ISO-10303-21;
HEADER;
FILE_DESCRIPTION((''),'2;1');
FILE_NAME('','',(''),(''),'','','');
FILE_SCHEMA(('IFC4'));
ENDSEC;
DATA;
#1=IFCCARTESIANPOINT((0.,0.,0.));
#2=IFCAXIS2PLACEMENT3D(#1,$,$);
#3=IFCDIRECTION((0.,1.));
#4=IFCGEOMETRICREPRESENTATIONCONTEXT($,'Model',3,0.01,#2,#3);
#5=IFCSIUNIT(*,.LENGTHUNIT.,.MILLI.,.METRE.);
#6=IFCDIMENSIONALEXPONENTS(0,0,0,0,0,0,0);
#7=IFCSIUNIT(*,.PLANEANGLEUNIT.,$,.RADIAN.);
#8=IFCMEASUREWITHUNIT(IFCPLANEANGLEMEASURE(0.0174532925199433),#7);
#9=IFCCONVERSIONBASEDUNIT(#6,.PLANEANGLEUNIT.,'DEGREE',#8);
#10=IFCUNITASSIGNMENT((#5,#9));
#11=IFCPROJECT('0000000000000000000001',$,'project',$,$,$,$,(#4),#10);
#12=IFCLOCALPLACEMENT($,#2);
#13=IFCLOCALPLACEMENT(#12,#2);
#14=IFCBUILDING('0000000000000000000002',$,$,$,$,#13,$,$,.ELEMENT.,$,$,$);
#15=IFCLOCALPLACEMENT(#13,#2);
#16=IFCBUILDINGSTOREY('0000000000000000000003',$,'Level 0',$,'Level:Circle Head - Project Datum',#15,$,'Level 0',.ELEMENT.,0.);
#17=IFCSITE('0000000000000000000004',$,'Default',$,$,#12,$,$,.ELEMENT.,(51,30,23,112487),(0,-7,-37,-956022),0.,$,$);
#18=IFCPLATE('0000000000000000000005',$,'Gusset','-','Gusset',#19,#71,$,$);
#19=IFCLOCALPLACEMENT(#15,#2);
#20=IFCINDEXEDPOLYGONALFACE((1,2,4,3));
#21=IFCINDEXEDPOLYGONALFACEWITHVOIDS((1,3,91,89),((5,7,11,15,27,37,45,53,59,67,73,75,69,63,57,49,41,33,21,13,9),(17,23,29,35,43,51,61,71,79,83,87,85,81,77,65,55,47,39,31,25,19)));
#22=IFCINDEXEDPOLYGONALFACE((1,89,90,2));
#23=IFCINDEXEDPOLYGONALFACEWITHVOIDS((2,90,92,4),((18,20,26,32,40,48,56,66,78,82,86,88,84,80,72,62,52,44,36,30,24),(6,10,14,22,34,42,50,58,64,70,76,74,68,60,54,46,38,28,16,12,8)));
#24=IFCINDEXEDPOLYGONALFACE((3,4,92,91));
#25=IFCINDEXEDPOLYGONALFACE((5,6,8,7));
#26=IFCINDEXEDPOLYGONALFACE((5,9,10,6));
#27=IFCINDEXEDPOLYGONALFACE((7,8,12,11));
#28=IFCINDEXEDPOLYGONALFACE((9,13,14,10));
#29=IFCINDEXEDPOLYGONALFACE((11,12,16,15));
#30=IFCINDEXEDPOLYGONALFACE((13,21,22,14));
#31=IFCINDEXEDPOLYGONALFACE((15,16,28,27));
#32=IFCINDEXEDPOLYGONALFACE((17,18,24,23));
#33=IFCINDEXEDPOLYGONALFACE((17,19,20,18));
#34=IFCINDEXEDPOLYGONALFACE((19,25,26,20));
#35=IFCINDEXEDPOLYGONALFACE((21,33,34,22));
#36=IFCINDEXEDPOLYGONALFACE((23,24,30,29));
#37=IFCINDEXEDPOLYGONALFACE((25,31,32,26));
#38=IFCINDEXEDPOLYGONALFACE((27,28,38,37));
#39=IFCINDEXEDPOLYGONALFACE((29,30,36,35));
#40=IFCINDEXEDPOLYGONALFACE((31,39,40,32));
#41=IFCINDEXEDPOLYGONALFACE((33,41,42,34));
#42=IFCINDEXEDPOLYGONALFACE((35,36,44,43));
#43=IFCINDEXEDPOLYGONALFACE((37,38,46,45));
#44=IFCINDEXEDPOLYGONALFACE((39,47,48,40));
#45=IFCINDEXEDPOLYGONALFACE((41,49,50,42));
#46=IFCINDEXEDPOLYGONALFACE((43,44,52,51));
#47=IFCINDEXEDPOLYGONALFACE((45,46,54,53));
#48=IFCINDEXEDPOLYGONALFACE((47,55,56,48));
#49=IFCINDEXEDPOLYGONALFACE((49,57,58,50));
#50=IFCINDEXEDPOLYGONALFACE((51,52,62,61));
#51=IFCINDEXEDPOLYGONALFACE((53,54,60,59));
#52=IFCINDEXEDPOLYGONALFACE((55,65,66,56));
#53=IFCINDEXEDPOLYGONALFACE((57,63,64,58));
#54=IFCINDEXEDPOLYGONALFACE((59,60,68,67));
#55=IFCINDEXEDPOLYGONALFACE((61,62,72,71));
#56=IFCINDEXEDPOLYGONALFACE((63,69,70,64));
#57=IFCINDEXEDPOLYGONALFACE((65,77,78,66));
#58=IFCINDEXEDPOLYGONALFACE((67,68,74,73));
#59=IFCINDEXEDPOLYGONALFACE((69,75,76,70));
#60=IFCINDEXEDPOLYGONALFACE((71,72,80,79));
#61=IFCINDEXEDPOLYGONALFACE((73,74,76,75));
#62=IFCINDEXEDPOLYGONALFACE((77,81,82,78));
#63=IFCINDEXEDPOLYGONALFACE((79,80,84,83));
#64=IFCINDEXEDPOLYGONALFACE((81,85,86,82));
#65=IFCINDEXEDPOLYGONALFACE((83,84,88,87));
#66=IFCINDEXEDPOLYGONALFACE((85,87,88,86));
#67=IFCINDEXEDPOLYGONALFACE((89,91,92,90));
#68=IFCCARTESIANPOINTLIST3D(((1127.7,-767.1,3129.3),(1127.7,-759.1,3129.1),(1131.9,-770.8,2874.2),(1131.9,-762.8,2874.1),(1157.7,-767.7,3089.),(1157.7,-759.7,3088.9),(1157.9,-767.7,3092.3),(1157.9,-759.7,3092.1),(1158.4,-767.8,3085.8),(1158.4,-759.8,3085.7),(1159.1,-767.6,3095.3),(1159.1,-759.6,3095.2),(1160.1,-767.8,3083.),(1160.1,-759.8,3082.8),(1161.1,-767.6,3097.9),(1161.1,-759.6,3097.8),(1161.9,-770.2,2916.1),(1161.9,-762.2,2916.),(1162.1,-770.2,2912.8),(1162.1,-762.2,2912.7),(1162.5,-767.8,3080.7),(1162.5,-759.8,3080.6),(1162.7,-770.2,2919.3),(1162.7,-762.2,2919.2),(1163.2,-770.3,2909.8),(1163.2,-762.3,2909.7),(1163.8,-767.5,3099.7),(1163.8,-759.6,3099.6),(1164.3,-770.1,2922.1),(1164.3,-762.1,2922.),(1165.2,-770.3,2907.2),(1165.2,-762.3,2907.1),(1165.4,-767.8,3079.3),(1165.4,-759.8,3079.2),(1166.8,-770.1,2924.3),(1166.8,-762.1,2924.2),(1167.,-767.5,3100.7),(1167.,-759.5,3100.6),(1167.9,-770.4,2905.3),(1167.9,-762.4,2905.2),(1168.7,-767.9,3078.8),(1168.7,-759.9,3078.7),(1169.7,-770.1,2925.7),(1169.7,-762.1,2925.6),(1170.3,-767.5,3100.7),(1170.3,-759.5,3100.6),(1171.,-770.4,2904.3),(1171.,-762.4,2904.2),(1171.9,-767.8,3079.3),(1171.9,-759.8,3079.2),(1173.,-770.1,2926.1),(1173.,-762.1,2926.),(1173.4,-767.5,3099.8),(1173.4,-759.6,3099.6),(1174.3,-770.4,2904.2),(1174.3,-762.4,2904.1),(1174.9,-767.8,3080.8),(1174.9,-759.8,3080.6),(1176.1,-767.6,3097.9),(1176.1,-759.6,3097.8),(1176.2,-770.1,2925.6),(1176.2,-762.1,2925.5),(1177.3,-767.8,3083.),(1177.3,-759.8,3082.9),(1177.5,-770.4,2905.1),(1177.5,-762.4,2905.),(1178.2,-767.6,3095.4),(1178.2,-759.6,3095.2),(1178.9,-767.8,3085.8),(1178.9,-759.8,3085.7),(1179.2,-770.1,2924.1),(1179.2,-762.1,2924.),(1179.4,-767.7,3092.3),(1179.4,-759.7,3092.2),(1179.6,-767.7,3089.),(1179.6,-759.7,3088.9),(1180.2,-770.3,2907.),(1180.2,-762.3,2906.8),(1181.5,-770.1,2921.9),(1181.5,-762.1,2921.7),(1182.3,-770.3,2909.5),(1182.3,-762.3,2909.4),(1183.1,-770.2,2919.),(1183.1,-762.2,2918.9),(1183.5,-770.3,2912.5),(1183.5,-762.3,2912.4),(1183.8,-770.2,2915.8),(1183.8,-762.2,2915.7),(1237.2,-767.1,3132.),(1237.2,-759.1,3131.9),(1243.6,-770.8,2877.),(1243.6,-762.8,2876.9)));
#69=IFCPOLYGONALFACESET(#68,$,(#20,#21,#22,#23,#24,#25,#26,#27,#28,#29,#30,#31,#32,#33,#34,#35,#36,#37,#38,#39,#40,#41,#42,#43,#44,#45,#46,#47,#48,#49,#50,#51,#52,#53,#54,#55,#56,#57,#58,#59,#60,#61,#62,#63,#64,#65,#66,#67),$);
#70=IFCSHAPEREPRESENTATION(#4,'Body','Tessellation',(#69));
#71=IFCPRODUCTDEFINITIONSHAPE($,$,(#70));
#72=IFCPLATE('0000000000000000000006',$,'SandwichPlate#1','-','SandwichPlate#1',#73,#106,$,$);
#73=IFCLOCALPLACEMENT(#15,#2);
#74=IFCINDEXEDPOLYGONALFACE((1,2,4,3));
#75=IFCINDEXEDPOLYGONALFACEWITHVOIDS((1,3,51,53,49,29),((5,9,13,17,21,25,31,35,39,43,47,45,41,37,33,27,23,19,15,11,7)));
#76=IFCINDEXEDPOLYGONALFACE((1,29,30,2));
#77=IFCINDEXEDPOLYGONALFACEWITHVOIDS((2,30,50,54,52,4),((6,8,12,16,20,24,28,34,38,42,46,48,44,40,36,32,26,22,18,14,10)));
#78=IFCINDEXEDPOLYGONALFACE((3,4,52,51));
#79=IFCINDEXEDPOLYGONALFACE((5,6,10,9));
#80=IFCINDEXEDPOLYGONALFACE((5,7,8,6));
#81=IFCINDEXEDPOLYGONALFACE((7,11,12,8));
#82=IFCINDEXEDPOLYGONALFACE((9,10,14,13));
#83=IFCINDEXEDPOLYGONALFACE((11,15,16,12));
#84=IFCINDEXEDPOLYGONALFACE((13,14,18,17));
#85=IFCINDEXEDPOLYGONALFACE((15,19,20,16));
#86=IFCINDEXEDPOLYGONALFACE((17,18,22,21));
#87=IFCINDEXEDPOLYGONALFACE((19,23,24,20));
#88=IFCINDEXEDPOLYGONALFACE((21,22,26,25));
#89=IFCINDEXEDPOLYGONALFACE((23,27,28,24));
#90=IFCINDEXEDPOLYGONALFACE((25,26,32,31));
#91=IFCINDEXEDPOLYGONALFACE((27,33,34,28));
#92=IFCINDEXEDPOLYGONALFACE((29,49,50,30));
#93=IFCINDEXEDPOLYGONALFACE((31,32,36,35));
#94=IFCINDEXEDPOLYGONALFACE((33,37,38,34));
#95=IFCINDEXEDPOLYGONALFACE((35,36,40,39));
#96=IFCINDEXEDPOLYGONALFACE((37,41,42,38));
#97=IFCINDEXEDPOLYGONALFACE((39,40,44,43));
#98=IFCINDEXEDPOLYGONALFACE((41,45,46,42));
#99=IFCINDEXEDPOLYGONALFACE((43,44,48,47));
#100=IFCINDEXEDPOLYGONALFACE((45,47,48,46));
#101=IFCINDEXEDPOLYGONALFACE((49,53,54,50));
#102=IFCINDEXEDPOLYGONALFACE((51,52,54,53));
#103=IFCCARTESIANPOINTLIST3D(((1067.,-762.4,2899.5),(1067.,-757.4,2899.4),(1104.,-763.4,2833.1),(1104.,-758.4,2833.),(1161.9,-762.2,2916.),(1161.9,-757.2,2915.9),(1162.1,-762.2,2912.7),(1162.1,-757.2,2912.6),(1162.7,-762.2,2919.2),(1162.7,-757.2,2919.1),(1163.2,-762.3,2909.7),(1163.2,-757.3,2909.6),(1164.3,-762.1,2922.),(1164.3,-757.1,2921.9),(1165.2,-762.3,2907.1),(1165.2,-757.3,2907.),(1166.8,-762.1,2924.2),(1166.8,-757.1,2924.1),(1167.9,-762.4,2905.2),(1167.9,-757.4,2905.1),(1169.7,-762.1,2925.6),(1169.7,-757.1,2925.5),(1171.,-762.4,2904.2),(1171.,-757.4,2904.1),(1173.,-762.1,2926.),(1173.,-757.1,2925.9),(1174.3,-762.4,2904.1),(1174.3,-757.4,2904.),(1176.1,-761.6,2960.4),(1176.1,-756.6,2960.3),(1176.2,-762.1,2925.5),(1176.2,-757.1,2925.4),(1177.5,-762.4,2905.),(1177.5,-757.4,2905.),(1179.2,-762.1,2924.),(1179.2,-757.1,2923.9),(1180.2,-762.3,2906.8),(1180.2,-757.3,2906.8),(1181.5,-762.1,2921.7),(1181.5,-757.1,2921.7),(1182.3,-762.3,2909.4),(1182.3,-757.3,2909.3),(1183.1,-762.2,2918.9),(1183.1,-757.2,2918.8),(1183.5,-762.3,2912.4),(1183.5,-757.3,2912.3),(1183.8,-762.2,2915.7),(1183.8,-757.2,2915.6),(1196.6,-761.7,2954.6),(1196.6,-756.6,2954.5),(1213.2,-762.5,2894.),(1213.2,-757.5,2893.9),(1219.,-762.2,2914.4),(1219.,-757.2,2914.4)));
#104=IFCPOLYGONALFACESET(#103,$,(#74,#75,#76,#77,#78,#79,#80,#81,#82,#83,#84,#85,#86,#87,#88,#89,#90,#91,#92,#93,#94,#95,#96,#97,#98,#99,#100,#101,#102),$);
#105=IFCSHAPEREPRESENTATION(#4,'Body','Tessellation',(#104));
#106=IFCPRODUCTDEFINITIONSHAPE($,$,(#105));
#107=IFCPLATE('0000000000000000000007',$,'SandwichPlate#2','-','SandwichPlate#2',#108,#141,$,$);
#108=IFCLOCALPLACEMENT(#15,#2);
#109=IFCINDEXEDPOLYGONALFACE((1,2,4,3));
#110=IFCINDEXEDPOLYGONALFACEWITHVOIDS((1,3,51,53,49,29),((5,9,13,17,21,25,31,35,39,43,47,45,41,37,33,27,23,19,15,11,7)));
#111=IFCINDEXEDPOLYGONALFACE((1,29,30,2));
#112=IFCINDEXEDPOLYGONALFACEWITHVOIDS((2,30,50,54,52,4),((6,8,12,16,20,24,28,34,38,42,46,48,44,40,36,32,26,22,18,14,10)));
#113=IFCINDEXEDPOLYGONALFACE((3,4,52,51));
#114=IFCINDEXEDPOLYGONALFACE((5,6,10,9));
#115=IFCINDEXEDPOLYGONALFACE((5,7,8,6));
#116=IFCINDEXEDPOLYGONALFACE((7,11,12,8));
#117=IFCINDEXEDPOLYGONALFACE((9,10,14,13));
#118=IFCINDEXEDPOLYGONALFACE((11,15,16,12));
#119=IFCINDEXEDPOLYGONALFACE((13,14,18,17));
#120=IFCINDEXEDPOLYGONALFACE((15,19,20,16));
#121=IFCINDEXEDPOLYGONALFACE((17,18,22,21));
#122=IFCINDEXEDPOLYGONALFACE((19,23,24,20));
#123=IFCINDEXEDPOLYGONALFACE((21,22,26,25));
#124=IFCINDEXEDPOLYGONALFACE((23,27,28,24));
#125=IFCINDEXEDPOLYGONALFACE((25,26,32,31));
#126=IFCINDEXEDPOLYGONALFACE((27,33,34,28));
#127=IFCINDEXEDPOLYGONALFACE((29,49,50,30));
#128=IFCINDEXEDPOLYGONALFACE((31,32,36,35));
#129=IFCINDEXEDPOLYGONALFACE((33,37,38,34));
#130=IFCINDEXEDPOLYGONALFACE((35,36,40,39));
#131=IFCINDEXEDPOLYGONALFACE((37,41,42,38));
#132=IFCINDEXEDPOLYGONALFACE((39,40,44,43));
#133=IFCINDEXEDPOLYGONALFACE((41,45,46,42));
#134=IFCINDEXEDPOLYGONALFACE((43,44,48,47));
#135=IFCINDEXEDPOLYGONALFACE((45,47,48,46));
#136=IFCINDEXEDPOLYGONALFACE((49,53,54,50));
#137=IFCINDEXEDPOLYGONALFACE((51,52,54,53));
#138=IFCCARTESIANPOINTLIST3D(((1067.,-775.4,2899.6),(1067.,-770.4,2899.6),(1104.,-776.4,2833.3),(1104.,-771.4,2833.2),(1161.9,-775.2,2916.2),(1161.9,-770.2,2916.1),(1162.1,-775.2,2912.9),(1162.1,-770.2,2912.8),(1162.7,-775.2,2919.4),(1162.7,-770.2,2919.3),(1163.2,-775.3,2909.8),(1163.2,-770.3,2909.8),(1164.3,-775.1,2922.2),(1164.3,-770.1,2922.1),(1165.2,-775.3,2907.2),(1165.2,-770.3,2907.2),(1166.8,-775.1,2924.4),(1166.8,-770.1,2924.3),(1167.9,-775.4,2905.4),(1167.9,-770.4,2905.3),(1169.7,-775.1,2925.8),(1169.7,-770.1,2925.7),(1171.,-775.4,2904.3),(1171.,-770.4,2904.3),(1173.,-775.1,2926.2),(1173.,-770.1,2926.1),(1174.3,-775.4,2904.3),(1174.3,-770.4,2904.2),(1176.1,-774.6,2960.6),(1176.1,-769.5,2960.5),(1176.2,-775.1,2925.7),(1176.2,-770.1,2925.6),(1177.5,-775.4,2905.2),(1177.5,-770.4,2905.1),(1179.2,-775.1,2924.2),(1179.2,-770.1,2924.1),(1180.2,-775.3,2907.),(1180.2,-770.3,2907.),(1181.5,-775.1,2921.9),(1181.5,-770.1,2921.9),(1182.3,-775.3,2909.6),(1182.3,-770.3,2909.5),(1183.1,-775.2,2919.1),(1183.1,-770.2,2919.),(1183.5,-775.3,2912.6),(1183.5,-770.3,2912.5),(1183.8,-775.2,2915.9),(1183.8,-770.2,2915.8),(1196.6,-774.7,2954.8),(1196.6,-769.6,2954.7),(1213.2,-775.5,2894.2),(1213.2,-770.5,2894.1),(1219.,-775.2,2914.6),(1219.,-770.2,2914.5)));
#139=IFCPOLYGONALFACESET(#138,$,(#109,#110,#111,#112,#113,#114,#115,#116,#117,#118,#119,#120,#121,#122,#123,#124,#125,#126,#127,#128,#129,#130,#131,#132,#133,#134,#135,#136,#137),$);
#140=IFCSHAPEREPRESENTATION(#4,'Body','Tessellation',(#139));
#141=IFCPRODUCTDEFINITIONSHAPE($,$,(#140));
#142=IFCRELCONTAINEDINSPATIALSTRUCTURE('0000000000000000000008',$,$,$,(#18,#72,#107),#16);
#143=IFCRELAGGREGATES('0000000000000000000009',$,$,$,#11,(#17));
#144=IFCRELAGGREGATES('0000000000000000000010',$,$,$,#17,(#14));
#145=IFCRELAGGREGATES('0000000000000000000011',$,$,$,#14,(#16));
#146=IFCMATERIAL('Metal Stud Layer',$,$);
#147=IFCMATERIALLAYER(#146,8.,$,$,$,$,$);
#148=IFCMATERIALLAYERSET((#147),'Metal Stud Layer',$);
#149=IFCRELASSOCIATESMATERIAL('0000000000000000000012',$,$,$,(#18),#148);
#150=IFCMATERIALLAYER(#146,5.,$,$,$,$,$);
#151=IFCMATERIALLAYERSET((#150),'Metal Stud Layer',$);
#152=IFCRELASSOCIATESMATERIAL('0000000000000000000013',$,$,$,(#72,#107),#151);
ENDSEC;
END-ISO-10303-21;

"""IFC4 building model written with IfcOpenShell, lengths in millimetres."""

from ifc_helpers import new_model, entity, si_unit, converted_unit, direction, frame, origin, origin_with_axes, origin_2d_with_axis, place, context, project, spatial, polyline, circle, outline, extrude, material, layer, layer_set, element, save


model = new_model("IFC4")

# Units and contexts
model_context_1 = context("Model", 3, precision=0.01, world=origin(), true_north=direction((0.0, 1.0)))
ifc_project = project(units=[si_unit("LENGTHUNIT", "METRE", prefix="MILLI"), converted_unit("PLANEANGLEUNIT", "DEGREE", entity("IfcPlaneAngleMeasure", 0.0174532925199433), si_unit("PLANEANGLEUNIT", "RADIAN"), dimensions=[0, 0, 0, 0, 0, 0, 0])], contexts=[model_context_1])

# Site, building, storey
site_placement = place(None, origin())
site = spatial("IfcSite", under=ifc_project, at=site_placement, Name="Default", CompositionType="ELEMENT", RefLatitude=(51, 30, 23, 112487), RefLongitude=(0, -7, -37, -956022), RefElevation=0.0)
building_placement = place(site_placement, origin())
building = spatial("IfcBuilding", under=site, at=building_placement, CompositionType="ELEMENT")
storey_placement = place(building_placement, origin())
storey = spatial("IfcBuildingStorey", under=building, at=storey_placement, Name="Level 0", ObjectType="Level:Circle Head - Project Datum", LongName="Level 0", CompositionType="ELEMENT", Elevation=0.0)

# Plates, openings
ifc_material_1 = material(Name="Metal Stud Layer")
ifc_layer_1 = layer(ifc_material_1, 8.0)
ifc_layer_set_1 = layer_set([ifc_layer_1], Name="Metal Stud Layer")
plate_1_placement = place(storey_placement, frame((1235.2, -767.1, 3131.9), z_axis=(0.0, 0.999896, -0.014432), x_axis=(0.02499, -0.014428, -0.999584)))
plate_1 = element("IfcPlate", 1, at=plate_1_placement, inside=storey, material=ifc_layer_set_1, Name="Gusset", Description="-", ObjectType="Gusset", context=model_context_1, shape_type="SweptSolid", body=[
    extrude(outline(polyline([(0.0, -2.0), (255.1, -2.0), (255.1, 109.7), (0.0, 107.5), (0.0, -2.0)])), origin_with_axes(), (0.0, 0.0, 1.0), 8.0),
])
opening_1_placement = place(plate_1_placement, frame((40.4, 67.6, 8.5), z_axis=(0.0, 0.0, -1.0), x_axis=(-0.51948, 0.854483, 0.0)))
element("IfcOpeningElement", 2, at=opening_1_placement, cuts=plate_1, ObjectType="Opening", context=model_context_1, shape_type="SweptSolid", body=[
    extrude(circle(Radius=11.0, at=origin_2d_with_axis()), origin(), (0.0, 0.0, 1.0), 9.0),
])
opening_2_placement = place(plate_1_placement, frame((215.2, 67.8, 8.5), z_axis=(0.0, 0.0, -1.0), x_axis=(0.465432, 0.885083, 0.0)))
element("IfcOpeningElement", 3, at=opening_2_placement, cuts=plate_1, ObjectType="Opening", context=model_context_1, shape_type="SweptSolid", body=[
    extrude(circle(Radius=11.0, at=origin_2d_with_axis()), origin(), (0.0, 0.0, 1.0), 9.0),
])
ifc_layer_2 = layer(ifc_material_1, 5.0)
ifc_layer_set_2 = layer_set([ifc_layer_2], Name="Metal Stud Layer")
plate_2_placement = place(storey_placement, frame((1226.3, -757.4, 2901.3), z_axis=(0.0, -0.999896, 0.014432), x_axis=(-0.487405, 0.012602, 0.873085)))
plate_2 = element("IfcPlate", 4, at=plate_2_placement, inside=storey, material=ifc_layer_set_2, Name="SandwichPlate#1", Description="-", ObjectType="SandwichPlate#1", context=model_context_1, shape_type="SweptSolid", body=[
    extrude(outline(polyline([(0.0, 0.0), (76.0, 0.0), (76.0, 140.0), (0.0, 140.0), (0.0, 0.0)])), origin_with_axes(), (0.0, 0.0, 1.0), 5.0),
])
opening_3_placement = place(plate_2_placement, frame((0.0, 0.0, 0.0), z_axis=(0.0, 0.0, 1.0), x_axis=(1.0, 0.0, 0.0)))
element("IfcOpeningElement", 5, at=opening_3_placement, cuts=plate_2, ObjectType="Opening", context=model_context_1, shape_type="SweptSolid", body=[
    extrude(outline(polyline([(0.0, 0.0), (15.0, 0.0), (0.0, 15.0), (0.0, 0.0)])), origin(), (0.0, 0.0, 1.0), 5.0),
])
opening_4_placement = place(plate_2_placement, frame((0.0, 0.0, 0.0), z_axis=(0.0, 0.0, 1.0), x_axis=(1.0, 0.0, 0.0)))
element("IfcOpeningElement", 6, at=opening_4_placement, cuts=plate_2, ObjectType="Opening", context=model_context_1, shape_type="SweptSolid", body=[
    extrude(outline(polyline([(76.0, 0.0), (76.0, 15.0), (61.0, 0.0), (76.0, 0.0)])), origin(), (0.0, 0.0, 1.0), 5.0),
])
opening_5_placement = place(plate_2_placement, frame((38.0, 40.0, -0.5), z_axis=(0.0, 0.0, 1.0), x_axis=(0.0, 1.0, 0.0)))
element("IfcOpeningElement", 7, at=opening_5_placement, cuts=plate_2, ObjectType="Opening", context=model_context_1, shape_type="SweptSolid", body=[
    extrude(circle(Radius=11.0, at=origin_2d_with_axis()), origin(), (0.0, 0.0, 1.0), 6.0),
])
plate_3_placement = place(storey_placement, frame((1226.3, -770.4, 2901.4), z_axis=(0.0, -0.999896, 0.014432), x_axis=(-0.487405, 0.012602, 0.873085)))
plate_3 = element("IfcPlate", 8, at=plate_3_placement, inside=storey, material=ifc_layer_set_2, Name="SandwichPlate#2", Description="-", ObjectType="SandwichPlate#2", context=model_context_1, shape_type="SweptSolid", body=[
    extrude(outline(polyline([(0.0, 0.0), (76.0, 0.0), (76.0, 140.0), (0.0, 140.0), (0.0, 0.0)])), origin_with_axes(), (0.0, 0.0, 1.0), 5.0),
])
opening_6_placement = place(plate_3_placement, frame((0.0, 0.0, 0.0), z_axis=(0.0, 0.0, 1.0), x_axis=(1.0, 0.0, 0.0)))
element("IfcOpeningElement", 9, at=opening_6_placement, cuts=plate_3, ObjectType="Opening", context=model_context_1, shape_type="SweptSolid", body=[
    extrude(outline(polyline([(0.0, 0.0), (15.0, 0.0), (0.0, 15.0), (0.0, 0.0)])), origin(), (0.0, 0.0, 1.0), 5.0),
])
opening_7_placement = place(plate_3_placement, frame((0.0, 0.0, 0.0), z_axis=(0.0, 0.0, 1.0), x_axis=(1.0, 0.0, 0.0)))
element("IfcOpeningElement", 10, at=opening_7_placement, cuts=plate_3, ObjectType="Opening", context=model_context_1, shape_type="SweptSolid", body=[
    extrude(outline(polyline([(76.0, 0.0), (76.0, 15.0), (61.0, 0.0), (76.0, 0.0)])), origin(), (0.0, 0.0, 1.0), 5.0),
])
opening_8_placement = place(plate_3_placement, frame((38.0, 40.0, -0.5), z_axis=(0.0, 0.0, 1.0), x_axis=(0.0, 1.0, 0.0)))
element("IfcOpeningElement", 11, at=opening_8_placement, cuts=plate_3, ObjectType="Opening", context=model_context_1, shape_type="SweptSolid", body=[
    extrude(circle(Radius=11.0, at=origin_2d_with_axis()), origin(), (0.0, 0.0, 1.0), 6.0),
])

save(model, "model.ifc")
